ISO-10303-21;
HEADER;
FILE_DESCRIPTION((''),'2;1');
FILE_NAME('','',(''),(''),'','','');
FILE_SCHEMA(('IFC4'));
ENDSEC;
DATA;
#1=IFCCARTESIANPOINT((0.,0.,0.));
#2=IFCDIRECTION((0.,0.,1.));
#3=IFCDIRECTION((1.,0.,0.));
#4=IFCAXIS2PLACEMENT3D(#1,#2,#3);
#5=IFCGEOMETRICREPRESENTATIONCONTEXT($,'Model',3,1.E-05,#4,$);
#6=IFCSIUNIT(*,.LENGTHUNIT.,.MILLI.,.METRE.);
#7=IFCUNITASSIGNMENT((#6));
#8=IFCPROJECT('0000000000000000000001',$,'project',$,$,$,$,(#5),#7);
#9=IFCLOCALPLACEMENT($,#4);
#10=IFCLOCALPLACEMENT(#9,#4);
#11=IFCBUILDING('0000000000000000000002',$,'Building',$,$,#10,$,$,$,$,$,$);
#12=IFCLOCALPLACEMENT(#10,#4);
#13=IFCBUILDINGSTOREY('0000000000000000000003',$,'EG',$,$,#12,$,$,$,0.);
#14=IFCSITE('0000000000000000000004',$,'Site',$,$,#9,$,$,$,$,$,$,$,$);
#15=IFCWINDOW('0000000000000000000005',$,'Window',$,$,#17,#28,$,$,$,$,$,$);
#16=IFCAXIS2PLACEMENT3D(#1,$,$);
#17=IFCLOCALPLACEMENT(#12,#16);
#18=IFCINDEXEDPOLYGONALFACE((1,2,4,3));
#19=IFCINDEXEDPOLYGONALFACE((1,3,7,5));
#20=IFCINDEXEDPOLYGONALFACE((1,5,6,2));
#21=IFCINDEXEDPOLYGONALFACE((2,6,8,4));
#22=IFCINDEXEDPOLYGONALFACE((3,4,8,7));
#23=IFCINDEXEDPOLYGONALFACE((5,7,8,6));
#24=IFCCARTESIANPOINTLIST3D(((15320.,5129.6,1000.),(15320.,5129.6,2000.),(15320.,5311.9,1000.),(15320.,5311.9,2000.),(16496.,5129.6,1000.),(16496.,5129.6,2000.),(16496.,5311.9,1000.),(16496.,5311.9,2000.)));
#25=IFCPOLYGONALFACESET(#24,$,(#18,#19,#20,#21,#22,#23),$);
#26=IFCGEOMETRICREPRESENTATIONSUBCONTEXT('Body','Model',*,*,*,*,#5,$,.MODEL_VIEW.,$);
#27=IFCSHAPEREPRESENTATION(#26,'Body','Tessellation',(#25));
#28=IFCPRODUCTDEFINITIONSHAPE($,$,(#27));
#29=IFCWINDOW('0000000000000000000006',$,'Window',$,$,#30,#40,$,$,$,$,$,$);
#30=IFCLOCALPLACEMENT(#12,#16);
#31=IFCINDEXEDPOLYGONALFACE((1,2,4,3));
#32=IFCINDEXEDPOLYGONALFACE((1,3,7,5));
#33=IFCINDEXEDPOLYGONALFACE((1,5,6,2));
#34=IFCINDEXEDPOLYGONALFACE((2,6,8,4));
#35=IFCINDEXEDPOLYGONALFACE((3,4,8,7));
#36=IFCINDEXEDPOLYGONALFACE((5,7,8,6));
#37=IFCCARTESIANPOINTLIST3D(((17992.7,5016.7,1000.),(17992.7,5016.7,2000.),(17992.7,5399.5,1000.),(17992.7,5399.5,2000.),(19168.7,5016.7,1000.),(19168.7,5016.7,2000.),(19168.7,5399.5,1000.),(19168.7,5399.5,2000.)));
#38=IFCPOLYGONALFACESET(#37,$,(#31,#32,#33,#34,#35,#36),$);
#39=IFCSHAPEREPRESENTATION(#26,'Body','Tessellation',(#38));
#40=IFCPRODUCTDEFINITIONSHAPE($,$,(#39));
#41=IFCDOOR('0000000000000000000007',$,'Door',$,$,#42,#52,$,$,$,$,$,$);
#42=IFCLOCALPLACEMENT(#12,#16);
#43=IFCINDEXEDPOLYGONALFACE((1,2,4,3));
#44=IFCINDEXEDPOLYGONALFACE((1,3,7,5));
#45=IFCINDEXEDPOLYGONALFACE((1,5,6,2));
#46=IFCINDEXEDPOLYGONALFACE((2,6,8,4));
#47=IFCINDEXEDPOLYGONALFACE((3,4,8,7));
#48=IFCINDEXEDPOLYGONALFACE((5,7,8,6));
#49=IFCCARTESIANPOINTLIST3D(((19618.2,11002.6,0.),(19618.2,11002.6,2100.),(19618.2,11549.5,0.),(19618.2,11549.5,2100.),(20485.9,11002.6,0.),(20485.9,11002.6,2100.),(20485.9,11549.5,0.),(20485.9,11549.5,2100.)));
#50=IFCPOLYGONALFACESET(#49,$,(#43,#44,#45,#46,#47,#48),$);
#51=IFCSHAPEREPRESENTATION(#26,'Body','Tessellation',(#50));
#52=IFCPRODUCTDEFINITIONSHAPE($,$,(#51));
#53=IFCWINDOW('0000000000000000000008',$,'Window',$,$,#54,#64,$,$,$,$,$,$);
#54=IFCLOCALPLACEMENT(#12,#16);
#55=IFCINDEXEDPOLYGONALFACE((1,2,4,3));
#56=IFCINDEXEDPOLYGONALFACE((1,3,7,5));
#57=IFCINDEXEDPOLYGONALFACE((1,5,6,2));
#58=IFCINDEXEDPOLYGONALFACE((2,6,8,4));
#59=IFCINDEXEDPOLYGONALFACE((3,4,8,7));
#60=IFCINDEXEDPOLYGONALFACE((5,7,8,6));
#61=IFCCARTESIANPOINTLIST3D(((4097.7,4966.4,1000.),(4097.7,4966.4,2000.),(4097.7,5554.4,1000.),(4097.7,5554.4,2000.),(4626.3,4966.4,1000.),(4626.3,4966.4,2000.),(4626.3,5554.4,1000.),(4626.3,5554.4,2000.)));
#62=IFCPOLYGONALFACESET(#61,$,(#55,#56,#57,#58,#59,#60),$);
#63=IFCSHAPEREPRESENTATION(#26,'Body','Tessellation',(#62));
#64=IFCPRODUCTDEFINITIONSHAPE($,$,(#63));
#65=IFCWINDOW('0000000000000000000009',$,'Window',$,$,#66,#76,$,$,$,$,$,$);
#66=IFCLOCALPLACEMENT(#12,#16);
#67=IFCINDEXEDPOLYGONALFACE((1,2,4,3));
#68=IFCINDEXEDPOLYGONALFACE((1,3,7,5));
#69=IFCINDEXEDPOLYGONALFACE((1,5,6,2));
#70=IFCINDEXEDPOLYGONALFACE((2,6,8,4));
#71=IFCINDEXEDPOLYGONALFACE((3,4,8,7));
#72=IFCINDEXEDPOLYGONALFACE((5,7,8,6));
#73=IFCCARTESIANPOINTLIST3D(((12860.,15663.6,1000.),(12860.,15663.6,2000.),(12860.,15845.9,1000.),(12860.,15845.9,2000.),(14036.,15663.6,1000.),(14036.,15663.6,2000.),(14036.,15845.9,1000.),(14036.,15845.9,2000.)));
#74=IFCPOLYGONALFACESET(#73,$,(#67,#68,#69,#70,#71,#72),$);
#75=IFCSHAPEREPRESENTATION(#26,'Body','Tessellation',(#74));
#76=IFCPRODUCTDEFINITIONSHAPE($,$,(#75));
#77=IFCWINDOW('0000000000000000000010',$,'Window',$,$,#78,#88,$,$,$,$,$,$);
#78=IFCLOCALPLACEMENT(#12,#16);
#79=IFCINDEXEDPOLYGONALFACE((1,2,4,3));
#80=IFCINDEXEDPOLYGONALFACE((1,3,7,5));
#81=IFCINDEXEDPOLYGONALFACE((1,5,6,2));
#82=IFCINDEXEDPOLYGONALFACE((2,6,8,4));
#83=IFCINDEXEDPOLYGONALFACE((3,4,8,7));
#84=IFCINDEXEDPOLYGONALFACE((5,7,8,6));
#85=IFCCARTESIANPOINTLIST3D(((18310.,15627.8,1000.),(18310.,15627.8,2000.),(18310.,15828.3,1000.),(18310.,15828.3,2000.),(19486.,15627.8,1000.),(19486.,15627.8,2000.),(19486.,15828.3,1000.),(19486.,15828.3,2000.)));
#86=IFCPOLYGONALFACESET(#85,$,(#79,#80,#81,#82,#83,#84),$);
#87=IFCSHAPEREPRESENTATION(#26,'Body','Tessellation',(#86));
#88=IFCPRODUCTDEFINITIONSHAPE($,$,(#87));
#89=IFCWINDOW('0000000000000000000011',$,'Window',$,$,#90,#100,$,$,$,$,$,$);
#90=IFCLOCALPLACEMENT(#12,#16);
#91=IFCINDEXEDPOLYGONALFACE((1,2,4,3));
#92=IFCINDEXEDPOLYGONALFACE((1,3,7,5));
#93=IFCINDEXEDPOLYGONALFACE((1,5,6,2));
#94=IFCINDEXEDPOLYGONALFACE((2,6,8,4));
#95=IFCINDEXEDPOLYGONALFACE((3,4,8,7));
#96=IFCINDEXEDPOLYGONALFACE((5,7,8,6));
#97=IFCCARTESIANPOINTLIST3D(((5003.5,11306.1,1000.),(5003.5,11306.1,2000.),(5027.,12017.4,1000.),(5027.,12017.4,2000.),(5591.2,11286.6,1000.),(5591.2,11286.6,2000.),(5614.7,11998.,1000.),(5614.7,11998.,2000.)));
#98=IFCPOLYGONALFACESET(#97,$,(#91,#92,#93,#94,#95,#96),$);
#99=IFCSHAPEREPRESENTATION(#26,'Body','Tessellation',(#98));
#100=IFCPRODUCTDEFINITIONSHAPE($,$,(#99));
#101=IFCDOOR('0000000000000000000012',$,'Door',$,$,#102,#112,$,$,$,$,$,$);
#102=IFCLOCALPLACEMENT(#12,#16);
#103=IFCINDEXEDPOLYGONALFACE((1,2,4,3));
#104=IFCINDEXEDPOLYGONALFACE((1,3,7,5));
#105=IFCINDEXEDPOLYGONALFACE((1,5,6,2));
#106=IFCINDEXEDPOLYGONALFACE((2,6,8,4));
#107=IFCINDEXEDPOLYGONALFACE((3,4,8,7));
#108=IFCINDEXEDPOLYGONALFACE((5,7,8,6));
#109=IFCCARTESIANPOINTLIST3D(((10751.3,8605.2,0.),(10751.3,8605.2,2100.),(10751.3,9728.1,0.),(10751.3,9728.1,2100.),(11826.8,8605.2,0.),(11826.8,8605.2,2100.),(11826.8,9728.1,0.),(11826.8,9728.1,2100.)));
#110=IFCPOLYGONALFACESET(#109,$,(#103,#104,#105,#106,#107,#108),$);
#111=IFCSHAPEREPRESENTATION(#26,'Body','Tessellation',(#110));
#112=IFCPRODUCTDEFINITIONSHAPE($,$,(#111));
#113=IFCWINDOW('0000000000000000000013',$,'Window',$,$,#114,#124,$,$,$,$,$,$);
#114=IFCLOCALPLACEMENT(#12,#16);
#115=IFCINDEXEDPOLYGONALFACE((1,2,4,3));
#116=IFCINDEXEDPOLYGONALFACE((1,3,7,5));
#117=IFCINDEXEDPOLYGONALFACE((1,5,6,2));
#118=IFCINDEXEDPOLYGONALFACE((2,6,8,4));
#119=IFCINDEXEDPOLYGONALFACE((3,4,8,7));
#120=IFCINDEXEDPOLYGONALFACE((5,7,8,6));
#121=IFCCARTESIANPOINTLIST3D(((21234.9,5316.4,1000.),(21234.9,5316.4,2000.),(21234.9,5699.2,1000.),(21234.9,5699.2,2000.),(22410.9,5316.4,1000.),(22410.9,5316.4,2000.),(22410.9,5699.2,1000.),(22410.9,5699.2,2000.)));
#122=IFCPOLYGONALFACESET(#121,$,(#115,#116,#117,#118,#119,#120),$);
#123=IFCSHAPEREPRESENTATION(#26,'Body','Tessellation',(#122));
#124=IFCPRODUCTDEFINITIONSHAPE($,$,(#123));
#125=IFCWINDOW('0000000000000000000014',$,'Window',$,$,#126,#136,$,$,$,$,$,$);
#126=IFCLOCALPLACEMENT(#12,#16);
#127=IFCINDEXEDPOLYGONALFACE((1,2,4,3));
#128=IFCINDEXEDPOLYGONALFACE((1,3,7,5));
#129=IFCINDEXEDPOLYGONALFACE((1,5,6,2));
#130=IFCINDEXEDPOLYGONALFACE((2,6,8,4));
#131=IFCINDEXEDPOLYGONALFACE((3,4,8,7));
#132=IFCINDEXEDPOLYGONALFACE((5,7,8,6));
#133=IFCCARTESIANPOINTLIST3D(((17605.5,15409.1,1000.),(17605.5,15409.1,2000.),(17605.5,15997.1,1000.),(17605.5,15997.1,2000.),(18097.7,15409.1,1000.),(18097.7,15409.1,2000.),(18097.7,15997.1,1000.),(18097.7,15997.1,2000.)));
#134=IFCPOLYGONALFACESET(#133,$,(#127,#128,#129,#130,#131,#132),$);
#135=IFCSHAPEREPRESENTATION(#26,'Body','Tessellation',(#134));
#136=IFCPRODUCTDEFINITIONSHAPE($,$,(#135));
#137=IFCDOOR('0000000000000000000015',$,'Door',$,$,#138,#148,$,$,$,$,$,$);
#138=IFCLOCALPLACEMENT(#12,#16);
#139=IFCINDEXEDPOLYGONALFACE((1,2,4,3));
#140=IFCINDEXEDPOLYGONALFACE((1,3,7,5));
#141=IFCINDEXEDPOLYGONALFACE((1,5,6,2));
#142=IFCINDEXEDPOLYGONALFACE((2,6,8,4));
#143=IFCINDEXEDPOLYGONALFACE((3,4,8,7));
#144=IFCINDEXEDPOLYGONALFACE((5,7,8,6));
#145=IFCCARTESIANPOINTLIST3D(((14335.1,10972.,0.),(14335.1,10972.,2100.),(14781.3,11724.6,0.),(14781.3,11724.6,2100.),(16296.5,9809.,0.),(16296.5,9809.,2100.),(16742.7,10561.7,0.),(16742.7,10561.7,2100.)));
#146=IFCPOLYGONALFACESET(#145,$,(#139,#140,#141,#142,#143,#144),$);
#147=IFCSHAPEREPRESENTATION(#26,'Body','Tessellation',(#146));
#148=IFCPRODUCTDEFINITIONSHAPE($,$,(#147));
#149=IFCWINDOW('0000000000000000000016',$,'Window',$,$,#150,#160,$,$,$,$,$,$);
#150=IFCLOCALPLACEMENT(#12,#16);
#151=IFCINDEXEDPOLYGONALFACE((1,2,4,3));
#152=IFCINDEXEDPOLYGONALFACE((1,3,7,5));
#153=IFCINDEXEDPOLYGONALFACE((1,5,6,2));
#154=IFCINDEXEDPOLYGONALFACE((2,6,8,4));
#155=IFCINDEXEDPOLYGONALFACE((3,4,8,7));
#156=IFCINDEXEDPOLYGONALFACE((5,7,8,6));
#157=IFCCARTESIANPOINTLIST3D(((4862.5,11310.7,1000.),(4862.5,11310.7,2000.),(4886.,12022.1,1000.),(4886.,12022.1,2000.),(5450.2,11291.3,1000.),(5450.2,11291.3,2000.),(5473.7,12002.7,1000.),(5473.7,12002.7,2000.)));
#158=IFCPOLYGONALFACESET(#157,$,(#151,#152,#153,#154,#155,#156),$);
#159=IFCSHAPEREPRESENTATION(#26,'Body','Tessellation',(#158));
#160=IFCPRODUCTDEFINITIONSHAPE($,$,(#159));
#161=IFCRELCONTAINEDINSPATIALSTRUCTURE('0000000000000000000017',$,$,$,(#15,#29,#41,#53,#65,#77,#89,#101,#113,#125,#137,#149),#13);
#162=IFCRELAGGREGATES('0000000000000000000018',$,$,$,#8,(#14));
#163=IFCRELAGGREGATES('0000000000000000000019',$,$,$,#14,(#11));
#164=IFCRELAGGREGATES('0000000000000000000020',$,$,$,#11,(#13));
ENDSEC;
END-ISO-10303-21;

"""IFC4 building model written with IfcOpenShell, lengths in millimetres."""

from ifc_helpers import new_model, si_unit, frame, origin_with_axes, place, context, subcontext, project, spatial, rectangle, extrude, element, save


model = new_model("IFC4")

# Units and contexts
model_context = context("Model", 3, precision=1e-05, world=origin_with_axes())
body_context = subcontext(model_context, "Body", "Model", "MODEL_VIEW")
ifc_project = project(units=[si_unit("LENGTHUNIT", "METRE", prefix="MILLI")], contexts=[model_context])

# Site, building, storey
site_placement = place(None, origin_with_axes())
site = spatial("IfcSite", under=ifc_project, at=site_placement, Name="Site")
building_placement = place(site_placement, origin_with_axes())
building = spatial("IfcBuilding", under=site, at=building_placement, Name="Building")
storey_placement = place(building_placement, origin_with_axes())
storey = spatial("IfcBuildingStorey", under=building, at=storey_placement, Name="EG", Elevation=0.0)

# Windows
window_1_placement = place(storey_placement, origin_with_axes())
element("IfcWindow", 1, at=window_1_placement, inside=storey, Name="Window", context=body_context, shape_type="SweptSolid", body=[
    extrude(rectangle(XDim=1176.0, YDim=182.3), frame((15908.0, 5220.7, 1000.0), z_axis=(0.0, 0.0, 1.0), x_axis=(1.0, 0.0, 0.0)), (0.0, 0.0, 1.0), 1000.0),
])
window_2_placement = place(storey_placement, origin_with_axes())
element("IfcWindow", 2, at=window_2_placement, inside=storey, Name="Window", context=body_context, shape_type="SweptSolid", body=[
    extrude(rectangle(XDim=1176.0, YDim=382.8), frame((18580.7, 5208.1, 1000.0), z_axis=(0.0, 0.0, 1.0), x_axis=(1.0, 0.0, 0.0)), (0.0, 0.0, 1.0), 1000.0),
])

# Door
door_1_placement = place(storey_placement, origin_with_axes())
element("IfcDoor", 3, at=door_1_placement, inside=storey, Name="Door", context=body_context, shape_type="SweptSolid", body=[
    extrude(rectangle(XDim=867.7, YDim=546.9), frame((20052.1, 11276.0, 0.0), z_axis=(0.0, 0.0, 1.0), x_axis=(1.0, 0.0, 0.0)), (0.0, 0.0, 1.0), 2100.0),
])

# Windows
window_3_placement = place(storey_placement, origin_with_axes())
element("IfcWindow", 4, at=window_3_placement, inside=storey, Name="Window", context=body_context, shape_type="SweptSolid", body=[
    extrude(rectangle(XDim=588.0, YDim=528.6), frame((4362.0, 5260.4, 1000.0), z_axis=(0.0, 0.0, 1.0), x_axis=(0.0, 1.0, 0.0)), (0.0, 0.0, 1.0), 1000.0),
])
window_4_placement = place(storey_placement, origin_with_axes())
element("IfcWindow", 5, at=window_4_placement, inside=storey, Name="Window", context=body_context, shape_type="SweptSolid", body=[
    extrude(rectangle(XDim=1176.0, YDim=182.3), frame((13448.0, 15754.8, 1000.0), z_axis=(0.0, 0.0, 1.0), x_axis=(1.0, 0.0, 0.0)), (0.0, 0.0, 1.0), 1000.0),
])
window_5_placement = place(storey_placement, origin_with_axes())
element("IfcWindow", 6, at=window_5_placement, inside=storey, Name="Window", context=body_context, shape_type="SweptSolid", body=[
    extrude(rectangle(XDim=1176.0, YDim=200.5), frame((18898.0, 15728.1, 1000.0), z_axis=(0.0, 0.0, 1.0), x_axis=(1.0, 0.0, 0.0)), (0.0, 0.0, 1.0), 1000.0),
])
window_6_placement = place(storey_placement, origin_with_axes())
element("IfcWindow", 7, at=window_6_placement, inside=storey, Name="Window", context=body_context, shape_type="SweptSolid", body=[
    extrude(rectangle(XDim=588.0, YDim=711.8), frame((5309.1, 11652.0, 1000.0), z_axis=(0.0, 0.0, 1.0), x_axis=(-0.999454, 0.03304, 0.0)), (0.0, 0.0, 1.0), 1000.0),
])

# Door
door_2_placement = place(storey_placement, origin_with_axes())
element("IfcDoor", 8, at=door_2_placement, inside=storey, Name="Door", context=body_context, shape_type="SweptSolid", body=[
    extrude(rectangle(XDim=1122.9, YDim=1075.5), frame((11289.1, 9166.7, 0.0), z_axis=(0.0, 0.0, 1.0), x_axis=(0.0, 1.0, 0.0)), (0.0, 0.0, 1.0), 2100.0),
])

# Windows
window_7_placement = place(storey_placement, origin_with_axes())
element("IfcWindow", 9, at=window_7_placement, inside=storey, Name="Window", context=body_context, shape_type="SweptSolid", body=[
    extrude(rectangle(XDim=1176.0, YDim=382.8), frame((21822.9, 5507.8, 1000.0), z_axis=(0.0, 0.0, 1.0), x_axis=(1.0, 0.0, 0.0)), (0.0, 0.0, 1.0), 1000.0),
])
window_8_placement = place(storey_placement, origin_with_axes())
element("IfcWindow", 10, at=window_8_placement, inside=storey, Name="Window", context=body_context, shape_type="SweptSolid", body=[
    extrude(rectangle(XDim=588.0, YDim=492.2), frame((17851.6, 15703.1, 1000.0), z_axis=(0.0, 0.0, 1.0), x_axis=(0.0, 1.0, 0.0)), (0.0, 0.0, 1.0), 1000.0),
])

# Door
door_3_placement = place(storey_placement, origin_with_axes())
element("IfcDoor", 11, at=door_3_placement, inside=storey, Name="Door", context=body_context, shape_type="SweptSolid", body=[
    extrude(rectangle(XDim=875.0, YDim=2280.3), frame((15538.9, 10766.8, 0.0), z_axis=(0.0, 0.0, 1.0), x_axis=(-0.510011, -0.860168, 0.0)), (0.0, 0.0, 1.0), 2100.0),
])

# Window
window_9_placement = place(storey_placement, origin_with_axes())
element("IfcWindow", 12, at=window_9_placement, inside=storey, Name="Window", context=body_context, shape_type="SweptSolid", body=[
    extrude(rectangle(XDim=588.0, YDim=711.8), frame((5168.1, 11656.7, 1000.0), z_axis=(0.0, 0.0, 1.0), x_axis=(-0.999454, 0.03304, 0.0)), (0.0, 0.0, 1.0), 1000.0),
])

save(model, "model.ifc")
